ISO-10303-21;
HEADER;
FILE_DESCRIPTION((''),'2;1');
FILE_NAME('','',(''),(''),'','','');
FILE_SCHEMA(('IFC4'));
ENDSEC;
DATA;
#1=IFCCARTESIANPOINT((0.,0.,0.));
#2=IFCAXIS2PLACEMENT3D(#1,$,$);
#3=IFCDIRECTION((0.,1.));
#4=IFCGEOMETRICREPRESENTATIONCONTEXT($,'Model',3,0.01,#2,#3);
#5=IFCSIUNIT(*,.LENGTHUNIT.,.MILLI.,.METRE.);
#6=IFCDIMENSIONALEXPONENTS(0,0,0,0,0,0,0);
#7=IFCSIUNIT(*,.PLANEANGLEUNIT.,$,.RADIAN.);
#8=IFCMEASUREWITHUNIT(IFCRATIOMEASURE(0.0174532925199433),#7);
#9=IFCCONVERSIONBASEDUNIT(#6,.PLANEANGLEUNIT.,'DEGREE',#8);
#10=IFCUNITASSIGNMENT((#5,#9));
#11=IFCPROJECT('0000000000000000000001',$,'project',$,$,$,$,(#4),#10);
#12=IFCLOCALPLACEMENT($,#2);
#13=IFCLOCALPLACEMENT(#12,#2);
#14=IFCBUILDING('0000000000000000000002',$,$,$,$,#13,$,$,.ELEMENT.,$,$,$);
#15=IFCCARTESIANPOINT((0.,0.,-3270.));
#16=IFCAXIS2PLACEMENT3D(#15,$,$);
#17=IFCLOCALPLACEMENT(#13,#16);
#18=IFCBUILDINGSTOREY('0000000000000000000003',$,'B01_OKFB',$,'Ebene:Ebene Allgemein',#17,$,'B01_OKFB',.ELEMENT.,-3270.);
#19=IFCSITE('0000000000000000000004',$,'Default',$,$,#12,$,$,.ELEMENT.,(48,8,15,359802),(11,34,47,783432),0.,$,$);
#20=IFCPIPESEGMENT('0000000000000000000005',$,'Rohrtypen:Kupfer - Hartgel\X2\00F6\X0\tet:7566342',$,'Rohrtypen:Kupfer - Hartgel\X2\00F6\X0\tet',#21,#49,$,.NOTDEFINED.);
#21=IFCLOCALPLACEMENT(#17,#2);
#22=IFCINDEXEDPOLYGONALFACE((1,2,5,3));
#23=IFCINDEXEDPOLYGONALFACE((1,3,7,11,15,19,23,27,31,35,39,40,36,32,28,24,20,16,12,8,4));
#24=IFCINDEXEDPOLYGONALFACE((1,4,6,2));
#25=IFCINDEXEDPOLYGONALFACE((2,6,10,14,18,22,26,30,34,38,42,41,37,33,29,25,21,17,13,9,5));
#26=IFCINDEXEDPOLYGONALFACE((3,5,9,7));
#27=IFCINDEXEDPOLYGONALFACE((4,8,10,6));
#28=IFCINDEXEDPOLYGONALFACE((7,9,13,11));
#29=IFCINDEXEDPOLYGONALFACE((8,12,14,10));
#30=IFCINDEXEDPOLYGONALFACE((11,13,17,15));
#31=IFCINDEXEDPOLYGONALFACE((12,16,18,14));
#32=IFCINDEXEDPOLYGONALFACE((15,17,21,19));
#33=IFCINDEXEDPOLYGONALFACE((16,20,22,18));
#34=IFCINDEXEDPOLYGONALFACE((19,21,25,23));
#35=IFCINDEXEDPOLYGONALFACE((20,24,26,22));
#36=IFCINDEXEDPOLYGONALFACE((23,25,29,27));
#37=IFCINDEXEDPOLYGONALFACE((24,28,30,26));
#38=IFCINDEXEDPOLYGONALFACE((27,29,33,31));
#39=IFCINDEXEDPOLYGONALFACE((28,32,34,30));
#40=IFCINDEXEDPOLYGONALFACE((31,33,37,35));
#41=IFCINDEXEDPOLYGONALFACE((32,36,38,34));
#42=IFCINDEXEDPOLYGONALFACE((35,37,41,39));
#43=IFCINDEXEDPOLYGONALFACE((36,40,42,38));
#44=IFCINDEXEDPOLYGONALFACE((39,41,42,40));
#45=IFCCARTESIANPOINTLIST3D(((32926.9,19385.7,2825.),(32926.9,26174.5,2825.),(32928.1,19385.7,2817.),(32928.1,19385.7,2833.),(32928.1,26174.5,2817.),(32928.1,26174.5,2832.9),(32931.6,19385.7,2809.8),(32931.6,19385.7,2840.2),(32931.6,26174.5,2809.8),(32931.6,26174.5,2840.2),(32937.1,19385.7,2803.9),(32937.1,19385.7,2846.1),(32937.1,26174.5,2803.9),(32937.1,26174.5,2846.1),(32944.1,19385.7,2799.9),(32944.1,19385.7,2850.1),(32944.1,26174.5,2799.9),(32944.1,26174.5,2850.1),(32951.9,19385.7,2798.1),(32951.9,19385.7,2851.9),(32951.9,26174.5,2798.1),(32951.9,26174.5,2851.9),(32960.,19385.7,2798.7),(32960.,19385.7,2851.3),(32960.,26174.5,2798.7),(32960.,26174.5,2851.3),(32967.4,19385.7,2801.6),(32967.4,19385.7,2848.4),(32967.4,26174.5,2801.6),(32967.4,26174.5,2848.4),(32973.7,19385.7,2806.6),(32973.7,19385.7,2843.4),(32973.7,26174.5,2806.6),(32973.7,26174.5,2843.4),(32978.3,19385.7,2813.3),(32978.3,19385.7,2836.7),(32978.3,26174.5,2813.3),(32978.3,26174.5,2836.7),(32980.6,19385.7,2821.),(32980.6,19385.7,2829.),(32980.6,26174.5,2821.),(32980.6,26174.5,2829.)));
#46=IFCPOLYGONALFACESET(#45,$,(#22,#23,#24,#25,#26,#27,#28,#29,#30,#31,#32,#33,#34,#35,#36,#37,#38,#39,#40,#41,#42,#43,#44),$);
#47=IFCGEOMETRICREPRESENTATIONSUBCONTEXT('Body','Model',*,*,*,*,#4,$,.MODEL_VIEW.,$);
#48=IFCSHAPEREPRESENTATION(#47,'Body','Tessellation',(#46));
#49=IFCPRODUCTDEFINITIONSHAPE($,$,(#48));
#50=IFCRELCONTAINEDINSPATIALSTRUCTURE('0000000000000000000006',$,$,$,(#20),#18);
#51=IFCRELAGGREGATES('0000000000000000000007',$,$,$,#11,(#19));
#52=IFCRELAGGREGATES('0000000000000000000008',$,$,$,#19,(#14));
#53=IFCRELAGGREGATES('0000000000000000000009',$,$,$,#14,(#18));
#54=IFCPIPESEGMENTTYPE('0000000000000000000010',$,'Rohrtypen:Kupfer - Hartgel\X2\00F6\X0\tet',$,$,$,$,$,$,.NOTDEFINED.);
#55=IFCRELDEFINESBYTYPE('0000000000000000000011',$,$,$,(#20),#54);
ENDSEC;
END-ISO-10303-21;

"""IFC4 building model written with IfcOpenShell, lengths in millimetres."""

from ifc_helpers import new_model, entity, si_unit, converted_unit, direction, frame, origin, origin_2d_with_axis, place, context, subcontext, project, spatial, circle, extrude, type_object, element, save


model = new_model("IFC4")

# Units and contexts
model_context = context("Model", 3, precision=0.01, world=origin(), true_north=direction((0.0, 1.0)))
body_context = subcontext(model_context, "Body", "Model", "MODEL_VIEW")
ifc_project = project(units=[si_unit("LENGTHUNIT", "METRE", prefix="MILLI"), converted_unit("PLANEANGLEUNIT", "DEGREE", entity("IfcRatioMeasure", 0.0174532925199433), si_unit("PLANEANGLEUNIT", "RADIAN"), dimensions=[0, 0, 0, 0, 0, 0, 0])], contexts=[model_context])

# Site, building, storey
site_placement = place(None, origin())
site = spatial("IfcSite", under=ifc_project, at=site_placement, Name="Default", CompositionType="ELEMENT", RefLatitude=(48, 8, 15, 359802), RefLongitude=(11, 34, 47, 783432), RefElevation=0.0)
building_placement = place(site_placement, origin())
building = spatial("IfcBuilding", under=site, at=building_placement, CompositionType="ELEMENT")
storey_placement = place(building_placement, frame((0.0, 0.0, -3270.0)))
storey = spatial("IfcBuildingStorey", under=building, at=storey_placement, Name="B01_OKFB", ObjectType="Ebene:Ebene Allgemein", LongName="B01_OKFB", CompositionType="ELEMENT", Elevation=-3270.0)

# Pipe segment
pipe_segment_type = type_object("IfcPipeSegmentType", Name="Rohrtypen:Kupfer - Hartgelötet", PredefinedType="NOTDEFINED")
pipe_segment_1_placement = place(storey_placement, frame((32925.4, 19385.7, 2796.4)))
element("IfcPipeSegment", 1, at=pipe_segment_1_placement, inside=storey, type_object=pipe_segment_type, Name="Rohrtypen:Kupfer - Hartgelötet:7566342", ObjectType="Rohrtypen:Kupfer - Hartgelötet", PredefinedType="NOTDEFINED", context=body_context, shape_type="SweptSolid", body=[
    extrude(circle(Radius=27.0, at=origin_2d_with_axis()), frame((28.6, 0.0, 28.6), z_axis=(0.0, 1.0, -0.000002), x_axis=(-1.0, 0.0, 0.0)), (0.0, 0.0, 1.0), 6788.8),
])

save(model, "model.ifc")
